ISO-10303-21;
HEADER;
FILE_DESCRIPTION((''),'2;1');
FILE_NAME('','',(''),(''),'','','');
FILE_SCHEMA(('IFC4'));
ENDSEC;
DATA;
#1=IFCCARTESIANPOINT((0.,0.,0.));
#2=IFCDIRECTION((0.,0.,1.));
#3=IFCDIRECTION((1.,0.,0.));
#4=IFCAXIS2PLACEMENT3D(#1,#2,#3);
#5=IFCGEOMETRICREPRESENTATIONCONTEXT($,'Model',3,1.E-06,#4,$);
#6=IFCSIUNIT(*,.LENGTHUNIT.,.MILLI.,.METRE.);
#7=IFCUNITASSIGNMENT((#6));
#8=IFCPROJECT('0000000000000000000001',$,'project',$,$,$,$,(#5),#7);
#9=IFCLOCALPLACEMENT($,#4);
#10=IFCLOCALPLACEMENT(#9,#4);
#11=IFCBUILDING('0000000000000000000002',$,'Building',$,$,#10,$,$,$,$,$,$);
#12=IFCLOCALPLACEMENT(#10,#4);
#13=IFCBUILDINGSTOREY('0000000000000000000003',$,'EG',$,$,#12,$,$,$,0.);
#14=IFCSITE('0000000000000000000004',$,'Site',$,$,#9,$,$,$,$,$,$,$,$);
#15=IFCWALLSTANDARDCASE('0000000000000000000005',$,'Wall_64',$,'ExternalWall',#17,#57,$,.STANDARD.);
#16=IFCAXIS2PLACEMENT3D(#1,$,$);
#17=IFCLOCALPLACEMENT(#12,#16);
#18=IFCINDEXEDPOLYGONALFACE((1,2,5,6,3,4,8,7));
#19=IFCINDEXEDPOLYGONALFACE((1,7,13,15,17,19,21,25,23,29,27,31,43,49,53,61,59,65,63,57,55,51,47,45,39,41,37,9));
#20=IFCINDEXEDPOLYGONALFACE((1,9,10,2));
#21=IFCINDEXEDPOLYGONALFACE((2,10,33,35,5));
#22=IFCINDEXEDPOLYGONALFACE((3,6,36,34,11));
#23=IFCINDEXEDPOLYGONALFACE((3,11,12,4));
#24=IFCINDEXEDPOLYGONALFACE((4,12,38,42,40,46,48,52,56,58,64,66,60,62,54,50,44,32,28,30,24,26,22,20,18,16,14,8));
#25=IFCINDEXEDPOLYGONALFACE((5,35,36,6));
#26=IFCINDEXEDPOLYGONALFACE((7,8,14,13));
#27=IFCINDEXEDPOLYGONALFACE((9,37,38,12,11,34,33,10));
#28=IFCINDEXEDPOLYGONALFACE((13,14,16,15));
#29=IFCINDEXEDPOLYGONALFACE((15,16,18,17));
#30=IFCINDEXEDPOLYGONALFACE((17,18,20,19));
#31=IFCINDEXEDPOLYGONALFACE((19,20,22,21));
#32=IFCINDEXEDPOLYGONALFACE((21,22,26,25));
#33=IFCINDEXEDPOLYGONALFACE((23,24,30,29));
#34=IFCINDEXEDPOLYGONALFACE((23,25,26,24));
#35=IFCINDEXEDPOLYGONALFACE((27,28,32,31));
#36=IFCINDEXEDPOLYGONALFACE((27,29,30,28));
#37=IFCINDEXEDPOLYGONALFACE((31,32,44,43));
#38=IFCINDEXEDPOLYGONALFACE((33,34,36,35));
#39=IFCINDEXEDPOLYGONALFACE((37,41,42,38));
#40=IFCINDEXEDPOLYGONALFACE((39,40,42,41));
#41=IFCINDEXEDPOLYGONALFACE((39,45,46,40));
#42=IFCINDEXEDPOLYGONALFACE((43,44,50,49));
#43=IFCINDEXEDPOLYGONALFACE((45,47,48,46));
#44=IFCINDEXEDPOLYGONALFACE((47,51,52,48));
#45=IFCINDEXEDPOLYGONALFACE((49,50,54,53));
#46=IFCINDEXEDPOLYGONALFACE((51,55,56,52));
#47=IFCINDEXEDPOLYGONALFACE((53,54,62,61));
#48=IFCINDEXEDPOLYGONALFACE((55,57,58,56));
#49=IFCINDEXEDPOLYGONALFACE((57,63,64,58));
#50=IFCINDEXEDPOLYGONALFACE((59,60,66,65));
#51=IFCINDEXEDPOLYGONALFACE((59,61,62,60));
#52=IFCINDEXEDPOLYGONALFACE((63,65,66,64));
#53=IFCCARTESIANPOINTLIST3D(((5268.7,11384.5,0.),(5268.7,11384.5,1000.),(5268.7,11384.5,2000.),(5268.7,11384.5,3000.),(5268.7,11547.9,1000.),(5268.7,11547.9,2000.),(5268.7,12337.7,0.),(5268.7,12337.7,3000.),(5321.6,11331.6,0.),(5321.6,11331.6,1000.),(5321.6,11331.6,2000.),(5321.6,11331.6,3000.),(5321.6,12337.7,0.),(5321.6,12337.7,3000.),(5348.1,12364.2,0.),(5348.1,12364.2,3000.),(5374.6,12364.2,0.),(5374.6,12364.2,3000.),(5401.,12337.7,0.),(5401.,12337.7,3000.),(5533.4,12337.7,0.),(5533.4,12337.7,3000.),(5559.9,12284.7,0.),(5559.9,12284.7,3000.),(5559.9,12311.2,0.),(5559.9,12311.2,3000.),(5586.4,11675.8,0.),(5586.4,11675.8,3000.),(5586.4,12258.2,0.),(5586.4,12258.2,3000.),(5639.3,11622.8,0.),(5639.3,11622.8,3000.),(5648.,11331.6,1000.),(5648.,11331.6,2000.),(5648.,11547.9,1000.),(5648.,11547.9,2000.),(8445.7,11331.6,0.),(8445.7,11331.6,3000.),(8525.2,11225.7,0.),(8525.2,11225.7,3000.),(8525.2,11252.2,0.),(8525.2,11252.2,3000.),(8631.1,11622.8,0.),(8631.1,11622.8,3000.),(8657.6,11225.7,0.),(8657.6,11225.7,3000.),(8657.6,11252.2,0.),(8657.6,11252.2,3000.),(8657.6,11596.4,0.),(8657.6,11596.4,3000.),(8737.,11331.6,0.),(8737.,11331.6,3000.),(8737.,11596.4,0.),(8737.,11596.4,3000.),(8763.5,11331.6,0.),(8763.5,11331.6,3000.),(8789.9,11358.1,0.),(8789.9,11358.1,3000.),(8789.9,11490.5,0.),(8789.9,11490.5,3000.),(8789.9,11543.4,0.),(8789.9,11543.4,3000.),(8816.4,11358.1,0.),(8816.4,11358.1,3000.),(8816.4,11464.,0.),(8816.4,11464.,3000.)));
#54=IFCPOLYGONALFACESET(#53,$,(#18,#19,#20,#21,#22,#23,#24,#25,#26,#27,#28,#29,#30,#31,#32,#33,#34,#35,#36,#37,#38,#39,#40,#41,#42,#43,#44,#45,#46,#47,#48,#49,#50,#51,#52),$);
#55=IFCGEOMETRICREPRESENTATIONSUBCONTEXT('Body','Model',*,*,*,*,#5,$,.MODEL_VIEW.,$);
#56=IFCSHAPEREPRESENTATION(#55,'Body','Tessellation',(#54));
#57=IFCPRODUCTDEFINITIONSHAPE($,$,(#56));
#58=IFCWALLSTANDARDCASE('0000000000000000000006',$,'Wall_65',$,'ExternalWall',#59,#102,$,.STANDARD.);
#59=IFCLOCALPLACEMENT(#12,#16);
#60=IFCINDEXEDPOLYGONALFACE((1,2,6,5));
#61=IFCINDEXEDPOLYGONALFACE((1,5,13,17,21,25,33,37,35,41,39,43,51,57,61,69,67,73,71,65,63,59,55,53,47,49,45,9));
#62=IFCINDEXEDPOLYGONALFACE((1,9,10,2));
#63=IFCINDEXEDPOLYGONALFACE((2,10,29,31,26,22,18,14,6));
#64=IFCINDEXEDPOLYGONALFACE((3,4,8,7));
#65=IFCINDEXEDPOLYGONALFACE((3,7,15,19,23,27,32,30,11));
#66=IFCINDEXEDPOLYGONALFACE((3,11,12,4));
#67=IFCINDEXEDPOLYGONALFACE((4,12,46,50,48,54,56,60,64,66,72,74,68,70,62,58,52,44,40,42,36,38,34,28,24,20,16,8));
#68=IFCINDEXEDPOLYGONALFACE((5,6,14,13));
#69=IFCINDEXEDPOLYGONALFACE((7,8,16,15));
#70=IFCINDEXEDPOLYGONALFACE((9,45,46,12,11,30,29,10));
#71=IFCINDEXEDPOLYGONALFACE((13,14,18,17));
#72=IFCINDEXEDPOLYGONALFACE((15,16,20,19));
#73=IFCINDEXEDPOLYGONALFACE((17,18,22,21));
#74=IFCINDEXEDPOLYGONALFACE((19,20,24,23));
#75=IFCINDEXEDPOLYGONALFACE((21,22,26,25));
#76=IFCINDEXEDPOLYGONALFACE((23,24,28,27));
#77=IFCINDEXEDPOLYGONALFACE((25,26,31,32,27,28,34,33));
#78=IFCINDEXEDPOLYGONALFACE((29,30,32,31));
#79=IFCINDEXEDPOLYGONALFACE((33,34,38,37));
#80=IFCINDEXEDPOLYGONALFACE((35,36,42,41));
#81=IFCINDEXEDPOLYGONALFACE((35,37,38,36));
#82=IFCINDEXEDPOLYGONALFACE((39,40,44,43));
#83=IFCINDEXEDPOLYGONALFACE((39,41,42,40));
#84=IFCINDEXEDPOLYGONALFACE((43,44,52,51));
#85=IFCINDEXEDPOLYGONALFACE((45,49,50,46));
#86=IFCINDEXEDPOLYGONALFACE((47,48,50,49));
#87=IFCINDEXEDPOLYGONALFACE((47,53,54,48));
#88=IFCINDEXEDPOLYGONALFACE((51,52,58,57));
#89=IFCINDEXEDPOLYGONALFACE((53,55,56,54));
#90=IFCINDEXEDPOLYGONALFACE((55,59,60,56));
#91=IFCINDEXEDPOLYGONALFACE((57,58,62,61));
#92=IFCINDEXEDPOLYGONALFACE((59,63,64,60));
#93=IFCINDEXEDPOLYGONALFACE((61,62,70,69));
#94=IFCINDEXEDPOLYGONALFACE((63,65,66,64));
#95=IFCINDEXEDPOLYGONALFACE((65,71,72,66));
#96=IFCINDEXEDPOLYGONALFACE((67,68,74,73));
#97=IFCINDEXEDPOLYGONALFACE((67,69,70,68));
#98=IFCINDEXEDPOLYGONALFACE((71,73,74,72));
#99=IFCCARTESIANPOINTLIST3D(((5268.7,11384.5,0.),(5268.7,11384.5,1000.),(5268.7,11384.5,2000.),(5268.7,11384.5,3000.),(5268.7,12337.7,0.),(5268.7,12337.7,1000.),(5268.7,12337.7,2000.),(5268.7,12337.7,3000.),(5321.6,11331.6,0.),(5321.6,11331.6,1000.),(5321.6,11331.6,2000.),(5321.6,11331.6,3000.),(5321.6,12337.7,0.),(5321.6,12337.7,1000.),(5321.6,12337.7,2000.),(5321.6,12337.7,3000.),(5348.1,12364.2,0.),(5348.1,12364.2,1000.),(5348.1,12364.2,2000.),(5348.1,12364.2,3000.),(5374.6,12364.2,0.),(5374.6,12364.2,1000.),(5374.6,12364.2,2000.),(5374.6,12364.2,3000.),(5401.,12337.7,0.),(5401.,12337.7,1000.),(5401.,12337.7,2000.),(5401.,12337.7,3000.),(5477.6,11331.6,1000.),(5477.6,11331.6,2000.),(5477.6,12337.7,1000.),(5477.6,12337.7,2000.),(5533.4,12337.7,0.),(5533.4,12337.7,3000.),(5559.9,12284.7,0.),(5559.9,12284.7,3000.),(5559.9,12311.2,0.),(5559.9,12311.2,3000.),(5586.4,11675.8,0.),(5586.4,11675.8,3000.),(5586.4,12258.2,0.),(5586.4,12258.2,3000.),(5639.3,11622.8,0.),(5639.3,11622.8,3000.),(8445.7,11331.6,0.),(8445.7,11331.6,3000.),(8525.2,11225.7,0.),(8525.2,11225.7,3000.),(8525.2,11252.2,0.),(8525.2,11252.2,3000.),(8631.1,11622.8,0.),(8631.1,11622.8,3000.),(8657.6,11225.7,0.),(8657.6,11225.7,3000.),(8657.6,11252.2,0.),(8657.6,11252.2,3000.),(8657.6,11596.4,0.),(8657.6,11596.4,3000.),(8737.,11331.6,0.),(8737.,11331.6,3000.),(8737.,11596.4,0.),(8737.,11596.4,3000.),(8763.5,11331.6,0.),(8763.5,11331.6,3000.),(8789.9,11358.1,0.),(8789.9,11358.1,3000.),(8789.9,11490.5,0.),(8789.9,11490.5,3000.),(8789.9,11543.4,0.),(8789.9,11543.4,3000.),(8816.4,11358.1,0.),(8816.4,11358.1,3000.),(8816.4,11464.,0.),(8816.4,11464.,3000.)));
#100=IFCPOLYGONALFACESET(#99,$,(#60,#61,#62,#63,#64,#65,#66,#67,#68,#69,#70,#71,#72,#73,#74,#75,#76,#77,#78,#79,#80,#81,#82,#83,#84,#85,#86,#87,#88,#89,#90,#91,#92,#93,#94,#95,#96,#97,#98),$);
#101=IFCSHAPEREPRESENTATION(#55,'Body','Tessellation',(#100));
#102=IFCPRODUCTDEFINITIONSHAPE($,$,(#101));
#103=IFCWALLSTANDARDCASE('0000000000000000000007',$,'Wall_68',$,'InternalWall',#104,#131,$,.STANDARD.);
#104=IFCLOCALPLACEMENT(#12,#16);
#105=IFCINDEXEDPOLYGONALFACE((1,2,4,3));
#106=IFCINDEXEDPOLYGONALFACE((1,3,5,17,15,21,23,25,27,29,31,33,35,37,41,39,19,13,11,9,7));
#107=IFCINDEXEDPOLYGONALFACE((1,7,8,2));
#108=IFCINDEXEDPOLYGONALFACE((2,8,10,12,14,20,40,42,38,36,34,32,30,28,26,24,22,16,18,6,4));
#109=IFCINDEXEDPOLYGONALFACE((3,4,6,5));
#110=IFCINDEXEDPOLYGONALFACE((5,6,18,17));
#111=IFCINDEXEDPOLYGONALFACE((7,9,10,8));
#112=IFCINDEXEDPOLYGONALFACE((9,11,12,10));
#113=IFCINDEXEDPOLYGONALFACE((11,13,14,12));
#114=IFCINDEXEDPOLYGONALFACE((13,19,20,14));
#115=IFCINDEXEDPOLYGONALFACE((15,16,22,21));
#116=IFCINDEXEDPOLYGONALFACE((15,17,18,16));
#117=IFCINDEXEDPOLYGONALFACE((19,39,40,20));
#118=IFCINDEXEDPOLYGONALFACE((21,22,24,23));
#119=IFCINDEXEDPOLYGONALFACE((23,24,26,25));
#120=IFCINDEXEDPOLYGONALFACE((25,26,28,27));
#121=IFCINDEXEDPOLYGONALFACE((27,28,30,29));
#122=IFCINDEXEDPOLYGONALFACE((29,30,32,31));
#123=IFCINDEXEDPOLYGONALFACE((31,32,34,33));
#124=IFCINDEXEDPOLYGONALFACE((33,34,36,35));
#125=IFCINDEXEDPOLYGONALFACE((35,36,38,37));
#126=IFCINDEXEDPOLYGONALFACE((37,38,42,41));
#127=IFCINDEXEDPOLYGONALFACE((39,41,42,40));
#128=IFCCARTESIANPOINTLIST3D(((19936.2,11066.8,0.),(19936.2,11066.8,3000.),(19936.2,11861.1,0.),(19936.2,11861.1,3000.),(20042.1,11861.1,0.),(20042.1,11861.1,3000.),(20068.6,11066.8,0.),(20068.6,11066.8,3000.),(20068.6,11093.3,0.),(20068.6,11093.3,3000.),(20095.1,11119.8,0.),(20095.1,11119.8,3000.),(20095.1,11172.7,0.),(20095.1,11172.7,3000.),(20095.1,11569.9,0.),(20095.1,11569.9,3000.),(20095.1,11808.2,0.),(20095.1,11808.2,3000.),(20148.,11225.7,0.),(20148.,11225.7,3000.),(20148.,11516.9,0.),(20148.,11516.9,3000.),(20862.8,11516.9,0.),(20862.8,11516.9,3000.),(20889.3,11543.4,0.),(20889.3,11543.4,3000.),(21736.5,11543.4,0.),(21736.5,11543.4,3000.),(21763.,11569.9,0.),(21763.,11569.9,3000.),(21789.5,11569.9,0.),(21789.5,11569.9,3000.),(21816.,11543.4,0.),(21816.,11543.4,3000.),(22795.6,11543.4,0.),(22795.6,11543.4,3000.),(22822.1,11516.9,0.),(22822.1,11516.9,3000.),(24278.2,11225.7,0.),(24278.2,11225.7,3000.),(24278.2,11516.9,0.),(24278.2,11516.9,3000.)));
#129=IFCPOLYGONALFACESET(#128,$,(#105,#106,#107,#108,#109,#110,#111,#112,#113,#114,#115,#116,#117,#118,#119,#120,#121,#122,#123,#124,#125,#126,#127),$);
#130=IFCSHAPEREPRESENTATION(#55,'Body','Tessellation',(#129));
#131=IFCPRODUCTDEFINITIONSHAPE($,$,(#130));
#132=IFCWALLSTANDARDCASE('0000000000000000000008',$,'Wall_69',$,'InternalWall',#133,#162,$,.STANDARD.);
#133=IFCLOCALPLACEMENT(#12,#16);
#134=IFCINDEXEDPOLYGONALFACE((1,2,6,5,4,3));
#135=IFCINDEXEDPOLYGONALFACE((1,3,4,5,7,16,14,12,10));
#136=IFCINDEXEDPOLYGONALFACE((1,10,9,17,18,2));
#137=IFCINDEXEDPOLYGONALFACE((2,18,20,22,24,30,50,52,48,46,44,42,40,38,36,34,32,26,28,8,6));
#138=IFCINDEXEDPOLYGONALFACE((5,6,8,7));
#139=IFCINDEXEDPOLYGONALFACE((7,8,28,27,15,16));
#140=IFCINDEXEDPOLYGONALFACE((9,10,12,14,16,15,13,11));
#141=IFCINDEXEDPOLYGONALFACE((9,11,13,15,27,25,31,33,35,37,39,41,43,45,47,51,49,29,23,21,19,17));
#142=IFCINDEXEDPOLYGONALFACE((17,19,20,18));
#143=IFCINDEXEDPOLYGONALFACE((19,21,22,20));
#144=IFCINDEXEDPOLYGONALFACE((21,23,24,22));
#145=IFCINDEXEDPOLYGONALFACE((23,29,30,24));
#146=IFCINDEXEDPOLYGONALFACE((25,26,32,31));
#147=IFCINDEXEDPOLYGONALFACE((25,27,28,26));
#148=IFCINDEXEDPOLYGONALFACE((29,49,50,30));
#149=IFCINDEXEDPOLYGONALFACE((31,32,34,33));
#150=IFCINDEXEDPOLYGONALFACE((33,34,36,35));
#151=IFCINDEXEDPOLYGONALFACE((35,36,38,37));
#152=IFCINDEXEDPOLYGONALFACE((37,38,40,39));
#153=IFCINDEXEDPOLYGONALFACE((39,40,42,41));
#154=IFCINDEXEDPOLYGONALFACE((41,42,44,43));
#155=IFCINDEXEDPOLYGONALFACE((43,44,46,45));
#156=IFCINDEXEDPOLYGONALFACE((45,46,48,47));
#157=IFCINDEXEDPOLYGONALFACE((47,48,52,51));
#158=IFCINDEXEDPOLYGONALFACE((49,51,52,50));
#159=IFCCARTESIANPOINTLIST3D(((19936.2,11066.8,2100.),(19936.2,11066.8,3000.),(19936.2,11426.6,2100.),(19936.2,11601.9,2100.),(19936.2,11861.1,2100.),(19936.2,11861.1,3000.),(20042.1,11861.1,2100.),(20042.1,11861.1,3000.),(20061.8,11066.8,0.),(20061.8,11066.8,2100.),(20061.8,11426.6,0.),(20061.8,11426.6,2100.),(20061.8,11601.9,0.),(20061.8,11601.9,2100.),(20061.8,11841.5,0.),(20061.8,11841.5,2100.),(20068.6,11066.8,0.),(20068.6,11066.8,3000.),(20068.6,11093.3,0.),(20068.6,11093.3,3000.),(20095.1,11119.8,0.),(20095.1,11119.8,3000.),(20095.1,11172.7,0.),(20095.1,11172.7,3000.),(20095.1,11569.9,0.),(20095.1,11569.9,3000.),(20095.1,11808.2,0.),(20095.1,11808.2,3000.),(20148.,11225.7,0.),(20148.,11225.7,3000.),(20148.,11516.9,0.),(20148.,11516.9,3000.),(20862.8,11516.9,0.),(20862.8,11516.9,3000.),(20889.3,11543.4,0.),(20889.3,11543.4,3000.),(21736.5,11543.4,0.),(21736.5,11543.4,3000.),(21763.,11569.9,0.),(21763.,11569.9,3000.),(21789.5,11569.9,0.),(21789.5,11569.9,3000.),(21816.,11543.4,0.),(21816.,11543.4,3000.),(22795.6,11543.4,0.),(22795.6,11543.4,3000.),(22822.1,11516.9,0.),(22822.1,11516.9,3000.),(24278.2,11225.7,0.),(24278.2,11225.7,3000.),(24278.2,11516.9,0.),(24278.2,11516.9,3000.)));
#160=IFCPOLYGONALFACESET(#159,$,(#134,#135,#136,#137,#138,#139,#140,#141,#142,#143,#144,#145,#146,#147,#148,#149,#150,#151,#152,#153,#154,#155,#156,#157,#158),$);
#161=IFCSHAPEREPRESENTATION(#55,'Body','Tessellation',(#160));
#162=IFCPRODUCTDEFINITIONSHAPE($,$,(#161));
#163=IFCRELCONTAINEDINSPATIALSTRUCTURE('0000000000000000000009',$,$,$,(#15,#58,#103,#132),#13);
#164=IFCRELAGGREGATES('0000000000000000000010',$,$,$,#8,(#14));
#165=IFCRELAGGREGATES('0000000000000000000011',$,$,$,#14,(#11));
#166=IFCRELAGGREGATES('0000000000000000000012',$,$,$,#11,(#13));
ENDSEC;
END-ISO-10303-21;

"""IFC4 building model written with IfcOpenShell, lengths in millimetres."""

from ifc_helpers import new_model, si_unit, frame, origin_with_axes, place, context, subcontext, project, spatial, polyline, rectangle, outline, extrude, element, save


model = new_model("IFC4")

# Units and contexts
model_context = context("Model", 3, precision=1e-06, world=origin_with_axes())
body_context = subcontext(model_context, "Body", "Model", "MODEL_VIEW")
ifc_project = project(units=[si_unit("LENGTHUNIT", "METRE", prefix="MILLI")], contexts=[model_context])

# Site, building, storey
site_placement = place(None, origin_with_axes())
site = spatial("IfcSite", under=ifc_project, at=site_placement, Name="Site")
building_placement = place(site_placement, origin_with_axes())
building = spatial("IfcBuilding", under=site, at=building_placement, Name="Building")
storey_placement = place(building_placement, origin_with_axes())
storey = spatial("IfcBuildingStorey", under=building, at=storey_placement, Name="EG", Elevation=0.0)

# Walls, openings
wall_1_placement = place(storey_placement, origin_with_axes())
wall_1 = element("IfcWallStandardCase", 1, at=wall_1_placement, inside=storey, Name="Wall_64", ObjectType="ExternalWall", PredefinedType="STANDARD", context=body_context, shape_type="SweptSolid", body=[
    extrude(outline(polyline([(8525.2, 11225.7, 0.0), (8525.2, 11252.2, 0.0), (8445.7, 11331.6, 0.0), (5321.6, 11331.6, 0.0), (5268.7, 11384.5, 0.0), (5268.7, 12337.7, 0.0), (5321.6, 12337.7, 0.0), (5348.1, 12364.2, 0.0), (5374.6, 12364.2, 0.0), (5401.0, 12337.7, 0.0), (5533.4, 12337.7, 0.0), (5559.9, 12311.2, 0.0), (5559.9, 12284.7, 0.0), (5586.4, 12258.2, 0.0), (5586.4, 11675.8, 0.0), (5639.3, 11622.8, 0.0), (8631.1, 11622.8, 0.0), (8657.6, 11596.4, 0.0), (8737.0, 11596.4, 0.0), (8789.9, 11543.4, 0.0), (8789.9, 11490.5, 0.0), (8816.4, 11464.0, 0.0), (8816.4, 11358.1, 0.0), (8789.9, 11358.1, 0.0), (8763.5, 11331.6, 0.0), (8737.0, 11331.6, 0.0), (8657.6, 11252.2, 0.0), (8657.6, 11225.7, 0.0), (8525.2, 11225.7, 0.0)])), origin_with_axes(), (0.0, 0.0, 1.0), 3000.0),
])
opening_1_placement = place(wall_1_placement, origin_with_axes())
element("IfcOpeningElement", 2, at=opening_1_placement, inside=storey, cuts=wall_1, context=body_context, shape_type="SweptSolid", body=[
    extrude(rectangle(XDim=636.5, YDim=300.0), frame((5329.8, 11397.9, 1000.0), z_axis=(0.0, 0.0, 1.0), x_axis=(1.0, 0.0, 0.0)), (0.0, 0.0, 1.0), 1000.0),
])
wall_2_placement = place(storey_placement, origin_with_axes())
wall_2 = element("IfcWallStandardCase", 3, at=wall_2_placement, inside=storey, Name="Wall_65", ObjectType="ExternalWall", PredefinedType="STANDARD", context=body_context, shape_type="SweptSolid", body=[
    extrude(outline(polyline([(8525.2, 11225.7, 0.0), (8525.2, 11252.2, 0.0), (8445.7, 11331.6, 0.0), (5321.6, 11331.6, 0.0), (5268.7, 11384.5, 0.0), (5268.7, 12337.7, 0.0), (5321.6, 12337.7, 0.0), (5348.1, 12364.2, 0.0), (5374.6, 12364.2, 0.0), (5401.0, 12337.7, 0.0), (5533.4, 12337.7, 0.0), (5559.9, 12311.2, 0.0), (5559.9, 12284.7, 0.0), (5586.4, 12258.2, 0.0), (5586.4, 11675.8, 0.0), (5639.3, 11622.8, 0.0), (8631.1, 11622.8, 0.0), (8657.6, 11596.4, 0.0), (8737.0, 11596.4, 0.0), (8789.9, 11543.4, 0.0), (8789.9, 11490.5, 0.0), (8816.4, 11464.0, 0.0), (8816.4, 11358.1, 0.0), (8789.9, 11358.1, 0.0), (8763.5, 11331.6, 0.0), (8737.0, 11331.6, 0.0), (8657.6, 11252.2, 0.0), (8657.6, 11225.7, 0.0), (8525.2, 11225.7, 0.0)])), origin_with_axes(), (0.0, 0.0, 1.0), 3000.0),
])
opening_2_placement = place(wall_2_placement, origin_with_axes())
element("IfcOpeningElement", 4, at=opening_2_placement, inside=storey, cuts=wall_2, context=body_context, shape_type="SweptSolid", body=[
    extrude(rectangle(XDim=2592.1, YDim=240.0), frame((5357.6, 12286.8, 1000.0), z_axis=(0.0, 0.0, 1.0), x_axis=(0.0, 1.0, 0.0)), (0.0, 0.0, 1.0), 1000.0),
])

# Wall
wall_3_placement = place(storey_placement, origin_with_axes())
element("IfcWallStandardCase", 5, at=wall_3_placement, inside=storey, Name="Wall_68", ObjectType="InternalWall", PredefinedType="STANDARD", context=body_context, shape_type="SweptSolid", body=[
    extrude(outline(polyline([(19936.2, 11066.8, 0.0), (19936.2, 11861.1, 0.0), (20042.1, 11861.1, 0.0), (20095.1, 11808.2, 0.0), (20095.1, 11569.9, 0.0), (20148.0, 11516.9, 0.0), (20862.8, 11516.9, 0.0), (20889.3, 11543.4, 0.0), (21736.5, 11543.4, 0.0), (21763.0, 11569.9, 0.0), (21789.5, 11569.9, 0.0), (21816.0, 11543.4, 0.0), (22795.6, 11543.4, 0.0), (22822.1, 11516.9, 0.0), (24278.2, 11516.9, 0.0), (24278.2, 11225.7, 0.0), (20148.0, 11225.7, 0.0), (20095.1, 11172.7, 0.0), (20095.1, 11119.8, 0.0), (20068.6, 11093.3, 0.0), (20068.6, 11066.8, 0.0), (19936.2, 11066.8, 0.0)])), origin_with_axes(), (0.0, 0.0, 1.0), 3000.0),
])

# Wall, openings
wall_4_placement = place(storey_placement, origin_with_axes())
wall_4 = element("IfcWallStandardCase", 6, at=wall_4_placement, inside=storey, Name="Wall_69", ObjectType="InternalWall", PredefinedType="STANDARD", context=body_context, shape_type="SweptSolid", body=[
    extrude(outline(polyline([(19936.2, 11066.8, 0.0), (19936.2, 11861.1, 0.0), (20042.1, 11861.1, 0.0), (20095.1, 11808.2, 0.0), (20095.1, 11569.9, 0.0), (20148.0, 11516.9, 0.0), (20862.8, 11516.9, 0.0), (20889.3, 11543.4, 0.0), (21736.5, 11543.4, 0.0), (21763.0, 11569.9, 0.0), (21789.5, 11569.9, 0.0), (21816.0, 11543.4, 0.0), (22795.6, 11543.4, 0.0), (22822.1, 11516.9, 0.0), (24278.2, 11516.9, 0.0), (24278.2, 11225.7, 0.0), (20148.0, 11225.7, 0.0), (20095.1, 11172.7, 0.0), (20095.1, 11119.8, 0.0), (20068.6, 11093.3, 0.0), (20068.6, 11066.8, 0.0), (19936.2, 11066.8, 0.0)])), origin_with_axes(), (0.0, 0.0, 1.0), 3000.0),
])
opening_3_placement = place(wall_4_placement, origin_with_axes())
element("IfcOpeningElement", 7, at=opening_3_placement, inside=storey, cuts=wall_4, context=body_context, shape_type="SweptSolid", body=[
    extrude(rectangle(XDim=1059.0, YDim=240.0), frame((19941.8, 11072.4, 0.0), z_axis=(0.0, 0.0, 1.0), x_axis=(0.0, 1.0, 0.0)), (0.0, 0.0, 1.0), 2100.0),
])
opening_4_placement = place(wall_4_placement, origin_with_axes())
element("IfcOpeningElement", 8, at=opening_4_placement, inside=storey, cuts=wall_4, context=body_context, shape_type="SweptSolid", body=[
    extrude(rectangle(XDim=847.2, YDim=240.0), frame((19941.8, 11850.2, 0.0), z_axis=(0.0, 0.0, 1.0), x_axis=(0.0, 1.0, 0.0)), (0.0, 0.0, 1.0), 2100.0),
])

save(model, "model.ifc")
